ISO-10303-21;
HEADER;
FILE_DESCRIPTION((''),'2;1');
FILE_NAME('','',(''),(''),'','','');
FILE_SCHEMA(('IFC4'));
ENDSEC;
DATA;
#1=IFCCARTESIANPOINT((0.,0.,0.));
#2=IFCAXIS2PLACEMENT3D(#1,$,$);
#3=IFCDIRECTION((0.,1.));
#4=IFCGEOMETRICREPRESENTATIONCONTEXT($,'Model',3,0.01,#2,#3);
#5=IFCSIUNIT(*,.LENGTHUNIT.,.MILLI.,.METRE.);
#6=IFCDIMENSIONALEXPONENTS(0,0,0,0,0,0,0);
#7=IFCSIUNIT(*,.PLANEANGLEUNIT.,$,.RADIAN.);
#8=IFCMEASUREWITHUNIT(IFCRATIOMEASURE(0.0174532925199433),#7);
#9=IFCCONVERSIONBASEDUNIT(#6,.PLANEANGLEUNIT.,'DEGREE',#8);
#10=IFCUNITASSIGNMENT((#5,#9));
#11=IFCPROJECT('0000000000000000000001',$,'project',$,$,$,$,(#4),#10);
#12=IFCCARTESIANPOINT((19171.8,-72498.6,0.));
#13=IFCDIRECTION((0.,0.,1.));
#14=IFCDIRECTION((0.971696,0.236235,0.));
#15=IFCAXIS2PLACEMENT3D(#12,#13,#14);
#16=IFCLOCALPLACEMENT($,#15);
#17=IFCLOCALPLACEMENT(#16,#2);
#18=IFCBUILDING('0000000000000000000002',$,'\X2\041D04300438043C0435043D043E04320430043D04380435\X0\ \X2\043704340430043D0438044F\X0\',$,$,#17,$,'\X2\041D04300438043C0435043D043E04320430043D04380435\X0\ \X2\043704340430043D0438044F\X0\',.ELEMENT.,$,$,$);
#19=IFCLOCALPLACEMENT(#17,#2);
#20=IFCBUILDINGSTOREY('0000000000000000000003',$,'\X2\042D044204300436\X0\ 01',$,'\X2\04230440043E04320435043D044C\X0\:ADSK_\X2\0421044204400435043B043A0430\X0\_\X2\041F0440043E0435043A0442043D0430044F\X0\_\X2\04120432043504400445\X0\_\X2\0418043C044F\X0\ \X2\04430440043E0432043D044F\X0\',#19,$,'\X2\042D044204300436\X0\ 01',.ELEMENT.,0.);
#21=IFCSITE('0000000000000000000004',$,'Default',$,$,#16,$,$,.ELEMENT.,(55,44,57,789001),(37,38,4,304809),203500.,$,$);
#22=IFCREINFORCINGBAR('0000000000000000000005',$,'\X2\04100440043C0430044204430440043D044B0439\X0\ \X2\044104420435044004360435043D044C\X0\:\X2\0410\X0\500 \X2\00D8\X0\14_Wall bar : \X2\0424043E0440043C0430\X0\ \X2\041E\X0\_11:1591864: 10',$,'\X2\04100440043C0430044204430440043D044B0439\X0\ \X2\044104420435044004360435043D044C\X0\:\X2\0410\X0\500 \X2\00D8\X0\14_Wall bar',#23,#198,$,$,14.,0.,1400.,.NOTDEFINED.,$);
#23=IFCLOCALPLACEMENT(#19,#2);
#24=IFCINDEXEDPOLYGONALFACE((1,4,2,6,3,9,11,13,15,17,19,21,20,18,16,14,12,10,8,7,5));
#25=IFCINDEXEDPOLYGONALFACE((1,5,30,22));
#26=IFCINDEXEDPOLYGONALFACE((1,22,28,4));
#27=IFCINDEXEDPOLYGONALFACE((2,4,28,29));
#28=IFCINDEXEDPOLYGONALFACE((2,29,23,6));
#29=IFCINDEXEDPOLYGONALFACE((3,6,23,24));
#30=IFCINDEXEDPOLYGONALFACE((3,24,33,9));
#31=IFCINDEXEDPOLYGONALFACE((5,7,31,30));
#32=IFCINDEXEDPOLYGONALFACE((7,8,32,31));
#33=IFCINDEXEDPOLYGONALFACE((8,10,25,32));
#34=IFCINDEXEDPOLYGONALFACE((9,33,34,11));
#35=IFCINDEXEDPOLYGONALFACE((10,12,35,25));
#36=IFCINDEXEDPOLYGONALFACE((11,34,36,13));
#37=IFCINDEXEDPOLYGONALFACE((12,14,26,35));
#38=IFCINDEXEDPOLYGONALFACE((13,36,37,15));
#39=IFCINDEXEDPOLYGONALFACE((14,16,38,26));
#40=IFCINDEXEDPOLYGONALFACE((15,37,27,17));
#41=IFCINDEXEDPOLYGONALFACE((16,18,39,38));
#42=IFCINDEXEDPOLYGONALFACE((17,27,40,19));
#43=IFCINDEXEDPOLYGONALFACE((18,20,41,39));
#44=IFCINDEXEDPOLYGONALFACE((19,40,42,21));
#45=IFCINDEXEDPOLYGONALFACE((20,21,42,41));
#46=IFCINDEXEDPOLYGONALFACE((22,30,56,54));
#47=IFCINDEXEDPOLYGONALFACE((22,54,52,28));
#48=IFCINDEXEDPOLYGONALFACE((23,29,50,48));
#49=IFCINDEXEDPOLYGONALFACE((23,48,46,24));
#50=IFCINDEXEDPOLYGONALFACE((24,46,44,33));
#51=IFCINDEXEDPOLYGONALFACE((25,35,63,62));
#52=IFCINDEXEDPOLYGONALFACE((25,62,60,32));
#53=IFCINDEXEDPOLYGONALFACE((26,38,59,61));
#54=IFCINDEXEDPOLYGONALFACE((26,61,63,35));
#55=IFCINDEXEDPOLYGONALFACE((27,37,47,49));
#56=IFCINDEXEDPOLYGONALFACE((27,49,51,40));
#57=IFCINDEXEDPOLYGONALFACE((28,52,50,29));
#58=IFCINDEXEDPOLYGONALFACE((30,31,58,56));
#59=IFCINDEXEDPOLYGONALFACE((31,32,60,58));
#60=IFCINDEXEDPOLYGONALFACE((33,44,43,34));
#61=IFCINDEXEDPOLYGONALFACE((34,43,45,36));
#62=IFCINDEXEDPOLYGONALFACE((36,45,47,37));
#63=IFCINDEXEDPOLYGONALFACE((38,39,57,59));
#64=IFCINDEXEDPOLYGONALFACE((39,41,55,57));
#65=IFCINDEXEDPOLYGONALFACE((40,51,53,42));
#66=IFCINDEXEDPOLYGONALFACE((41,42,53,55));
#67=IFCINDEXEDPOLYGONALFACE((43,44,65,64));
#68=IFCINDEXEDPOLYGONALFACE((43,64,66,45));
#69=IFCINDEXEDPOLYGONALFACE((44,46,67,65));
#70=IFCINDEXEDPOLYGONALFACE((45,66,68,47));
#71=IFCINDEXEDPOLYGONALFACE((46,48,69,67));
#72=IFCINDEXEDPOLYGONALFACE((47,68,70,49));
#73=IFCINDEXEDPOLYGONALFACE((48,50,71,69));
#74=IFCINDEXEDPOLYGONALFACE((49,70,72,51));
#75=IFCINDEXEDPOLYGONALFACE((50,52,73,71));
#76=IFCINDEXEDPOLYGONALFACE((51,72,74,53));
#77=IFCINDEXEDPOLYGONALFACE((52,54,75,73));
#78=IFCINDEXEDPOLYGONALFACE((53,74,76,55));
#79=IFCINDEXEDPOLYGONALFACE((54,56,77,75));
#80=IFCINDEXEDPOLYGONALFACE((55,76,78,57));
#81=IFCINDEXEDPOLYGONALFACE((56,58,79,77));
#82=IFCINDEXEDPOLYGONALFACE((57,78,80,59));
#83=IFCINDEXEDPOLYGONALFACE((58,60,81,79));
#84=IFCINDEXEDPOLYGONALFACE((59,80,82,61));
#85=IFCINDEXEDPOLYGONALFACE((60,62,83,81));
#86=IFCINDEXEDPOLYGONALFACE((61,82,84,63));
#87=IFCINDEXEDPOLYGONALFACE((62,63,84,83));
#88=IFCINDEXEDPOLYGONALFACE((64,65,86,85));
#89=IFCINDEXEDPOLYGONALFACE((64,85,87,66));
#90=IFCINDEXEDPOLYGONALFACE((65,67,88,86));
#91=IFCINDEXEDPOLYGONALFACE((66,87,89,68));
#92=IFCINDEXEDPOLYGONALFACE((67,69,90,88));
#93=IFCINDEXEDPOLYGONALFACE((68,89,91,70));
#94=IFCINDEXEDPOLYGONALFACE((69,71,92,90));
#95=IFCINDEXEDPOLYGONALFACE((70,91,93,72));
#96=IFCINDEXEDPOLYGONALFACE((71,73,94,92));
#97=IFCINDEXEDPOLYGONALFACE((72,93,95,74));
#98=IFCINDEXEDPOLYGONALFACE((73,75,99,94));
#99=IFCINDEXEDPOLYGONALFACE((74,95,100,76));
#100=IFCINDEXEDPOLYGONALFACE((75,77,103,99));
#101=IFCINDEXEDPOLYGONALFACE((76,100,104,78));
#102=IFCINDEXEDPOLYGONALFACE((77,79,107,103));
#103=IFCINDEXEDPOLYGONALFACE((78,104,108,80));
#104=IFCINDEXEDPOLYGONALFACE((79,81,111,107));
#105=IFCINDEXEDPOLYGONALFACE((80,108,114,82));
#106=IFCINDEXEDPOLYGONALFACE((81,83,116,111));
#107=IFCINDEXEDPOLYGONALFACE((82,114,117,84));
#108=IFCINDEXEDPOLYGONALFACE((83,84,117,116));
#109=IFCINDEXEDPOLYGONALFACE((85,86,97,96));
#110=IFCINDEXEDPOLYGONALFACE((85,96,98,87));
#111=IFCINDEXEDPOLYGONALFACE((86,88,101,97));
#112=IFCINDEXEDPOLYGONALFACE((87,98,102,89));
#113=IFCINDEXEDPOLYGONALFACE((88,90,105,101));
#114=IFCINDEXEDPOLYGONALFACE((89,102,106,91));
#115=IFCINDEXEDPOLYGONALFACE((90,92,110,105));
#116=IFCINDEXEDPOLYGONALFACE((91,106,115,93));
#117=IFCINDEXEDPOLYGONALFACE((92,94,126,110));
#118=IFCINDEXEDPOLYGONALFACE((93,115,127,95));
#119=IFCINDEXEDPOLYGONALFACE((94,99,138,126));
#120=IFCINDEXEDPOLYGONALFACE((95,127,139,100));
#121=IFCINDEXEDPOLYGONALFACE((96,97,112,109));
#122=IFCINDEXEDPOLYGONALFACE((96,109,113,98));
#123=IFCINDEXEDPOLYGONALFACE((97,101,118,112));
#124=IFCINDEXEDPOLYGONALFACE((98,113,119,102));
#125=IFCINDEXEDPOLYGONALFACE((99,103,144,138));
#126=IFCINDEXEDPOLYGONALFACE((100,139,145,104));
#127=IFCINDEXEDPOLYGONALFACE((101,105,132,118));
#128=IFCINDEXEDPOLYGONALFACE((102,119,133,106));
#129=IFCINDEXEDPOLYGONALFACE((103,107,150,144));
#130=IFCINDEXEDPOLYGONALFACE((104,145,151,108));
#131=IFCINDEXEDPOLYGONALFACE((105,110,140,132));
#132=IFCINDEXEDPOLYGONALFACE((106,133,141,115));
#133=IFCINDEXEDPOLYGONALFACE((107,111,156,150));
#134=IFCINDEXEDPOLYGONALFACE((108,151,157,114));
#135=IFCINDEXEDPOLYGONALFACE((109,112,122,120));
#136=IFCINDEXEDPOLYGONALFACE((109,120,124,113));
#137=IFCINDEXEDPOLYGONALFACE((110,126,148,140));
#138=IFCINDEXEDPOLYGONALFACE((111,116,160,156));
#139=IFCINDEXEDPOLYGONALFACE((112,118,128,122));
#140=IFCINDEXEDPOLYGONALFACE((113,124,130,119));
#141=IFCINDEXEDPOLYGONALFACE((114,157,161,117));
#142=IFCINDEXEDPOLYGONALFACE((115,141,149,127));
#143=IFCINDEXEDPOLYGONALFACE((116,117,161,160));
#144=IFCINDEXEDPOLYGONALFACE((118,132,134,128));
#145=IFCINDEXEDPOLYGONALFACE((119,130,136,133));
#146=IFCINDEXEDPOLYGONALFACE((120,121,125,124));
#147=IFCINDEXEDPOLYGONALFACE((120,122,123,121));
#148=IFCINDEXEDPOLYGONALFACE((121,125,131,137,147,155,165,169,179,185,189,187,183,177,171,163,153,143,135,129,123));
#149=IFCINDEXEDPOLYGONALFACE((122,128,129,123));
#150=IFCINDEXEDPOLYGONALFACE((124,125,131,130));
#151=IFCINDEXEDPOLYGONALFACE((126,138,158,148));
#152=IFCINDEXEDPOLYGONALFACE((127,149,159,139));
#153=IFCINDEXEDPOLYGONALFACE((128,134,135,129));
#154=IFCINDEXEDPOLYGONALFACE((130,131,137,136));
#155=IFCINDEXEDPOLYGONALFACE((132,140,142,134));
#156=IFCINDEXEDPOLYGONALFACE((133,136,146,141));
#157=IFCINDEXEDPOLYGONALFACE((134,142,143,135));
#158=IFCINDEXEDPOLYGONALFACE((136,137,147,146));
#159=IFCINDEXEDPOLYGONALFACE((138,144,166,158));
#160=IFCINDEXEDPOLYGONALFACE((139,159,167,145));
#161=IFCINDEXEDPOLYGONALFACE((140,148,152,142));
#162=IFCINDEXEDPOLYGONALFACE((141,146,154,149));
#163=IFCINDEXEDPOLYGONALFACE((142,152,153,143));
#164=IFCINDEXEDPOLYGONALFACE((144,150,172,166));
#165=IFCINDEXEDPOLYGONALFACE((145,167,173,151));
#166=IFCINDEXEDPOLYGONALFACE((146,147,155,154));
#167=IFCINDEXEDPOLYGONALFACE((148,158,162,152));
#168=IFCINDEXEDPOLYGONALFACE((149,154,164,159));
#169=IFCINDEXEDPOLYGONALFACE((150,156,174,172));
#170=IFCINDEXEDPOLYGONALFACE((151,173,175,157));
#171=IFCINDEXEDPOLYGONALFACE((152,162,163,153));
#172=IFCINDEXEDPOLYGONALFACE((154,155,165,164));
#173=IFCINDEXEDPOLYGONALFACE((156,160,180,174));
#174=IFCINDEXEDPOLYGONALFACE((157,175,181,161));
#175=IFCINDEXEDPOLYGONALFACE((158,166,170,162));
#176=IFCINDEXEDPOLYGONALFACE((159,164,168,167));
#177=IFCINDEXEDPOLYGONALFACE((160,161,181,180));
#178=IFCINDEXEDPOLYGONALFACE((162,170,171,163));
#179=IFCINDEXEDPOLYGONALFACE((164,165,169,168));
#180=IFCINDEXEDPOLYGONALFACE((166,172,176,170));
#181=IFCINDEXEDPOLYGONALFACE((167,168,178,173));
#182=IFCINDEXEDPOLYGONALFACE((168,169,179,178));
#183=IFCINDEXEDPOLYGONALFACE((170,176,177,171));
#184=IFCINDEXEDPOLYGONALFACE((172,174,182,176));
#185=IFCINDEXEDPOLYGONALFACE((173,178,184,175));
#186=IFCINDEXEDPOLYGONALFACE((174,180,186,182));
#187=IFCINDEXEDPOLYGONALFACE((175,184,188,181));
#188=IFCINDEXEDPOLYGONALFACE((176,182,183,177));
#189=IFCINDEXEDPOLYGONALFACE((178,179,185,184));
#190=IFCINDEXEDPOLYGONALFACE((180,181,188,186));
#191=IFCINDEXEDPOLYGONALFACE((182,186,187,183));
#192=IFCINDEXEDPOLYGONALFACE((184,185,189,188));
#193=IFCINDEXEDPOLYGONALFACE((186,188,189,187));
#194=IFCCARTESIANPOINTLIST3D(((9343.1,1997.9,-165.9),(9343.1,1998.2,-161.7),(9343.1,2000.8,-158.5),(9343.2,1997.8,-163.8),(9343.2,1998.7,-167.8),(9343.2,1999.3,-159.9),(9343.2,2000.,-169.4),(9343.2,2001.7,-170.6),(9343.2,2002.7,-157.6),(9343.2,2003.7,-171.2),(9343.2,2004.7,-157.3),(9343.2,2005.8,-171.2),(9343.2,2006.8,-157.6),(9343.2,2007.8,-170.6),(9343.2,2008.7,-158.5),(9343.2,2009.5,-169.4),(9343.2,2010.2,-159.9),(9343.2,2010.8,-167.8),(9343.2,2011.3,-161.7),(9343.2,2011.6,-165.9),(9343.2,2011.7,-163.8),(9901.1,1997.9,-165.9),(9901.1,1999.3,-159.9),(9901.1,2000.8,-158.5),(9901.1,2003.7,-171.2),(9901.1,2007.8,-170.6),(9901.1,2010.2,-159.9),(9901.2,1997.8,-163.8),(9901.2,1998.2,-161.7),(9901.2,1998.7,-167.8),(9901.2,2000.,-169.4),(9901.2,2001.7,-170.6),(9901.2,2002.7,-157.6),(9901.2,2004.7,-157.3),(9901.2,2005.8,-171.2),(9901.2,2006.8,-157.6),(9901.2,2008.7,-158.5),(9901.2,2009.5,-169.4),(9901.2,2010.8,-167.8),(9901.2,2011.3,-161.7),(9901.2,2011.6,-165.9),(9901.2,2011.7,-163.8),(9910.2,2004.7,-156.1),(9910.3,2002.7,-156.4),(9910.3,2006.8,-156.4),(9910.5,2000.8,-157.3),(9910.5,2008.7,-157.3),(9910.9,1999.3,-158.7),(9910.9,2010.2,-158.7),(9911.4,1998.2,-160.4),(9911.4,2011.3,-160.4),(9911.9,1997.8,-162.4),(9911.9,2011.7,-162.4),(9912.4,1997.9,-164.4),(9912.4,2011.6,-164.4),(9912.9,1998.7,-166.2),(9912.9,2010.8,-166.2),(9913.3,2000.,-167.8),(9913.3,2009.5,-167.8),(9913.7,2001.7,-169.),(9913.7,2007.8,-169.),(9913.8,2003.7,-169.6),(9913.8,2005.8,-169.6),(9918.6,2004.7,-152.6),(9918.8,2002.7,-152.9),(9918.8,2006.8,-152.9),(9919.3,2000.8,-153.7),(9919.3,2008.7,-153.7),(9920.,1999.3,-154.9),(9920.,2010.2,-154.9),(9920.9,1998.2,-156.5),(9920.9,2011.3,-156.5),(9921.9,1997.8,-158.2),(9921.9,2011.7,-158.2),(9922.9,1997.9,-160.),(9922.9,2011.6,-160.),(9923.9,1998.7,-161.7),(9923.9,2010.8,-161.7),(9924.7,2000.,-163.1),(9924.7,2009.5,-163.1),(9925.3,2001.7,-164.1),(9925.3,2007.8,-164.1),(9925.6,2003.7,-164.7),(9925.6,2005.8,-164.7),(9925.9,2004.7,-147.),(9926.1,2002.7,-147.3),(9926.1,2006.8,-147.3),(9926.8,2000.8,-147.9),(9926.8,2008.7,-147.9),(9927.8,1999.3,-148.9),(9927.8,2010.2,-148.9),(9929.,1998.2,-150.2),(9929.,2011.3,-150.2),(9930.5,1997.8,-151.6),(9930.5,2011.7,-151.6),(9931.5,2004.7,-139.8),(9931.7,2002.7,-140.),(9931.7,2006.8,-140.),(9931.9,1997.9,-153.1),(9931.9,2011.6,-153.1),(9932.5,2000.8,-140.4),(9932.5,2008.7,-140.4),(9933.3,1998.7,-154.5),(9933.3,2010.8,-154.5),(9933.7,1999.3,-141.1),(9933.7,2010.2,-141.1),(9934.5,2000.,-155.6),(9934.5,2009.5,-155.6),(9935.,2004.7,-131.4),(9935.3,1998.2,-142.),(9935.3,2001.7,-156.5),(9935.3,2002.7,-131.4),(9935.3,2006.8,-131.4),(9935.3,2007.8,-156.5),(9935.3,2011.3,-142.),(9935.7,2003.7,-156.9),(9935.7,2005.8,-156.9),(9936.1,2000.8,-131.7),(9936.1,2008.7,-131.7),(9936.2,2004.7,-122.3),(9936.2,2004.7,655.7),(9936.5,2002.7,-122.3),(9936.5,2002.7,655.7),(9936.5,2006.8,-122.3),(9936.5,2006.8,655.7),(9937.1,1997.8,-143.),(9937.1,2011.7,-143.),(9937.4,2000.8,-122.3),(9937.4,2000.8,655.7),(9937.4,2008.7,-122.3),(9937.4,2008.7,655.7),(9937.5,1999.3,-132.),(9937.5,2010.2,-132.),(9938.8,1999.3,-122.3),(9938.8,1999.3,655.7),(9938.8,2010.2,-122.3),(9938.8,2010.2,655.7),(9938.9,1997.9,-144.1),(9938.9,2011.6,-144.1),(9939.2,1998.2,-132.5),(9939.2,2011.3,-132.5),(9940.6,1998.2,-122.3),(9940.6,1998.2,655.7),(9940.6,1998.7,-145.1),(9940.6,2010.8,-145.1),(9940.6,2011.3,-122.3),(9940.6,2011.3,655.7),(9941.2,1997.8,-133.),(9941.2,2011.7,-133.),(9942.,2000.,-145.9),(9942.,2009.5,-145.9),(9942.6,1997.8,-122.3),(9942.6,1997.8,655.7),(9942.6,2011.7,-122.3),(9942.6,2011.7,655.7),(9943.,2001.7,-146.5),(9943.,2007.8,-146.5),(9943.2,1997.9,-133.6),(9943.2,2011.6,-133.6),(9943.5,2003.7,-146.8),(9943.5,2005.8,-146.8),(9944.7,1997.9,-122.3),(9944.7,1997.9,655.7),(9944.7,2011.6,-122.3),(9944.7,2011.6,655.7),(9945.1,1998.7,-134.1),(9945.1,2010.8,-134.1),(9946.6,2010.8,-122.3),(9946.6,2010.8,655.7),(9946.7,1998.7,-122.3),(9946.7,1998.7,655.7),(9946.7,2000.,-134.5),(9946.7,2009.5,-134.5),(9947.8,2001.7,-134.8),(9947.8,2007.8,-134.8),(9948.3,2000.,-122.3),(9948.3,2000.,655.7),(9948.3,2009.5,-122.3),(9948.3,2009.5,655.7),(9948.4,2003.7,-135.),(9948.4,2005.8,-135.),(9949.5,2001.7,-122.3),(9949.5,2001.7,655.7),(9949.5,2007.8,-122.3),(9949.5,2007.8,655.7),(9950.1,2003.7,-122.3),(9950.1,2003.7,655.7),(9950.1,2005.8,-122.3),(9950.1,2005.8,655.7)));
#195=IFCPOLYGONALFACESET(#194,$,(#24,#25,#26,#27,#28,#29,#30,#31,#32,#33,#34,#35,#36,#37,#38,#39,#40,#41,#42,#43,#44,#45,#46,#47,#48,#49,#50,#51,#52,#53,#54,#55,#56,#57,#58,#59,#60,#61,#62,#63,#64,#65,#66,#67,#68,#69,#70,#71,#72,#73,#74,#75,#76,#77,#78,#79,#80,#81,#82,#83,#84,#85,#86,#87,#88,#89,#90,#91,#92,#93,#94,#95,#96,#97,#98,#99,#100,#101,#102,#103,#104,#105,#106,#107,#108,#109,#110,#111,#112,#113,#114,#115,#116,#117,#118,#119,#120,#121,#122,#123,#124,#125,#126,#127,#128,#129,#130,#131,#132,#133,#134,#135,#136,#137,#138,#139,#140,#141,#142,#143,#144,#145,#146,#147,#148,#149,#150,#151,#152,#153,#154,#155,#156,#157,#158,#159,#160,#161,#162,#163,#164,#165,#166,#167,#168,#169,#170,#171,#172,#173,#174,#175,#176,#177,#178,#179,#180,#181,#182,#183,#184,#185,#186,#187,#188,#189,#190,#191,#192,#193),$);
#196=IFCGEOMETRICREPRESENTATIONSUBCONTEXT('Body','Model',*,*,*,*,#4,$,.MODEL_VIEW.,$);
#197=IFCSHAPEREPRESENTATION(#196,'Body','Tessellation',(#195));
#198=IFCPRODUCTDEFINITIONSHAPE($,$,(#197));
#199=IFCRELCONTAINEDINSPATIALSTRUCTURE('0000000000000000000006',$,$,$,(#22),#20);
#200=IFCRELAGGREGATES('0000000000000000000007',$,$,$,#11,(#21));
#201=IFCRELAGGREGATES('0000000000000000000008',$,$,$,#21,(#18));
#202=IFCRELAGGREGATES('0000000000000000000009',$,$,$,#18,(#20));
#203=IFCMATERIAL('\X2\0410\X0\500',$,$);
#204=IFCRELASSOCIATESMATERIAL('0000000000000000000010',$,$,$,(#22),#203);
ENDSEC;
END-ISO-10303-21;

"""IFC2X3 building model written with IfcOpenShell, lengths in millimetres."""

from ifc_helpers import new_model, entity, si_unit, converted_unit, direction, frame, origin, place, context, subcontext, project, spatial, material, element, save


model = new_model("IFC2X3")

# Units and contexts
model_context = context("Model", 3, precision=0.01, world=origin(), true_north=direction((0.0, 1.0)))
body_context = subcontext(model_context, "Body", "Model", "MODEL_VIEW")
ifc_project = project(units=[si_unit("LENGTHUNIT", "METRE", prefix="MILLI"), converted_unit("PLANEANGLEUNIT", "DEGREE", entity("IfcRatioMeasure", 0.0174532925199433), si_unit("PLANEANGLEUNIT", "RADIAN"), dimensions=[0, 0, 0, 0, 0, 0, 0])], contexts=[model_context])

# Site, building, storey
site_placement = place(None, frame((19171.8, -72498.6, 0.0), z_axis=(0.0, 0.0, 1.0), x_axis=(0.971696, 0.236235, 0.0)))
site = spatial("IfcSite", under=ifc_project, at=site_placement, Name="Default", CompositionType="ELEMENT", RefLatitude=(55, 44, 57, 789001), RefLongitude=(37, 38, 4, 304809), RefElevation=203500.0)
building_placement = place(site_placement, origin())
building = spatial("IfcBuilding", under=site, at=building_placement, Name="Наименование здания", LongName="Наименование здания", CompositionType="ELEMENT")
storey_placement = place(building_placement, origin())
storey = spatial("IfcBuildingStorey", under=building, at=storey_placement, Name="Этаж 01", ObjectType="Уровень:ADSK_Стрелка_Проектная_Вверх_Имя уровня", LongName="Этаж 01", CompositionType="ELEMENT", Elevation=0.0)

# Reinforcing bar
ifc_material = material(Name="А500")
placement = place(storey_placement, origin())
element("IfcReinforcingBar", 1, at=placement, inside=storey, material=ifc_material, Name="Арматурный стержень:А500 Ø14_Wall bar : Форма О_11:1591864: 10", ObjectType="Арматурный стержень:А500 Ø14_Wall bar", BarLength=1400.0, BarRole="NOTDEFINED", CrossSectionArea=0.0, NominalDiameter=14.0, context=body_context, shape_type="AdvancedSweptSolid", body=[
    entity("IfcSweptDiskSolid", entity("IfcCompositeCurve", [entity("IfcCompositeCurveSegment", "CONTINUOUS", True, entity("IfcPolyline", [entity("IfcCartesianPoint", [9943.1, 2004.7, 655.7]), entity("IfcCartesianPoint", [9943.1, 2004.7, -122.3])])), entity("IfcCompositeCurveSegment", "CONTINUOUS", True, entity("IfcTrimmedCurve", entity("IfcCircle", entity("IfcAxis2Placement3D", entity("IfcCartesianPoint", [9901.1, 2004.7, -122.3]), entity("IfcDirection", [0.0, 1.0, 0.0]), entity("IfcDirection", [0.0, 0.0, -1.0])), 42.0), [entity("IfcParameterValue", 270.0)], [entity("IfcParameterValue", 360.0)], True, "PARAMETER")), entity("IfcCompositeCurveSegment", "CONTINUOUS", True, entity("IfcPolyline", [entity("IfcCartesianPoint", [9901.1, 2004.7, -164.3]), entity("IfcCartesianPoint", [9343.1, 2004.7, -164.3])]))], False), 7.0, None, 0.0, 92.0),
])

save(model, "model.ifc")
